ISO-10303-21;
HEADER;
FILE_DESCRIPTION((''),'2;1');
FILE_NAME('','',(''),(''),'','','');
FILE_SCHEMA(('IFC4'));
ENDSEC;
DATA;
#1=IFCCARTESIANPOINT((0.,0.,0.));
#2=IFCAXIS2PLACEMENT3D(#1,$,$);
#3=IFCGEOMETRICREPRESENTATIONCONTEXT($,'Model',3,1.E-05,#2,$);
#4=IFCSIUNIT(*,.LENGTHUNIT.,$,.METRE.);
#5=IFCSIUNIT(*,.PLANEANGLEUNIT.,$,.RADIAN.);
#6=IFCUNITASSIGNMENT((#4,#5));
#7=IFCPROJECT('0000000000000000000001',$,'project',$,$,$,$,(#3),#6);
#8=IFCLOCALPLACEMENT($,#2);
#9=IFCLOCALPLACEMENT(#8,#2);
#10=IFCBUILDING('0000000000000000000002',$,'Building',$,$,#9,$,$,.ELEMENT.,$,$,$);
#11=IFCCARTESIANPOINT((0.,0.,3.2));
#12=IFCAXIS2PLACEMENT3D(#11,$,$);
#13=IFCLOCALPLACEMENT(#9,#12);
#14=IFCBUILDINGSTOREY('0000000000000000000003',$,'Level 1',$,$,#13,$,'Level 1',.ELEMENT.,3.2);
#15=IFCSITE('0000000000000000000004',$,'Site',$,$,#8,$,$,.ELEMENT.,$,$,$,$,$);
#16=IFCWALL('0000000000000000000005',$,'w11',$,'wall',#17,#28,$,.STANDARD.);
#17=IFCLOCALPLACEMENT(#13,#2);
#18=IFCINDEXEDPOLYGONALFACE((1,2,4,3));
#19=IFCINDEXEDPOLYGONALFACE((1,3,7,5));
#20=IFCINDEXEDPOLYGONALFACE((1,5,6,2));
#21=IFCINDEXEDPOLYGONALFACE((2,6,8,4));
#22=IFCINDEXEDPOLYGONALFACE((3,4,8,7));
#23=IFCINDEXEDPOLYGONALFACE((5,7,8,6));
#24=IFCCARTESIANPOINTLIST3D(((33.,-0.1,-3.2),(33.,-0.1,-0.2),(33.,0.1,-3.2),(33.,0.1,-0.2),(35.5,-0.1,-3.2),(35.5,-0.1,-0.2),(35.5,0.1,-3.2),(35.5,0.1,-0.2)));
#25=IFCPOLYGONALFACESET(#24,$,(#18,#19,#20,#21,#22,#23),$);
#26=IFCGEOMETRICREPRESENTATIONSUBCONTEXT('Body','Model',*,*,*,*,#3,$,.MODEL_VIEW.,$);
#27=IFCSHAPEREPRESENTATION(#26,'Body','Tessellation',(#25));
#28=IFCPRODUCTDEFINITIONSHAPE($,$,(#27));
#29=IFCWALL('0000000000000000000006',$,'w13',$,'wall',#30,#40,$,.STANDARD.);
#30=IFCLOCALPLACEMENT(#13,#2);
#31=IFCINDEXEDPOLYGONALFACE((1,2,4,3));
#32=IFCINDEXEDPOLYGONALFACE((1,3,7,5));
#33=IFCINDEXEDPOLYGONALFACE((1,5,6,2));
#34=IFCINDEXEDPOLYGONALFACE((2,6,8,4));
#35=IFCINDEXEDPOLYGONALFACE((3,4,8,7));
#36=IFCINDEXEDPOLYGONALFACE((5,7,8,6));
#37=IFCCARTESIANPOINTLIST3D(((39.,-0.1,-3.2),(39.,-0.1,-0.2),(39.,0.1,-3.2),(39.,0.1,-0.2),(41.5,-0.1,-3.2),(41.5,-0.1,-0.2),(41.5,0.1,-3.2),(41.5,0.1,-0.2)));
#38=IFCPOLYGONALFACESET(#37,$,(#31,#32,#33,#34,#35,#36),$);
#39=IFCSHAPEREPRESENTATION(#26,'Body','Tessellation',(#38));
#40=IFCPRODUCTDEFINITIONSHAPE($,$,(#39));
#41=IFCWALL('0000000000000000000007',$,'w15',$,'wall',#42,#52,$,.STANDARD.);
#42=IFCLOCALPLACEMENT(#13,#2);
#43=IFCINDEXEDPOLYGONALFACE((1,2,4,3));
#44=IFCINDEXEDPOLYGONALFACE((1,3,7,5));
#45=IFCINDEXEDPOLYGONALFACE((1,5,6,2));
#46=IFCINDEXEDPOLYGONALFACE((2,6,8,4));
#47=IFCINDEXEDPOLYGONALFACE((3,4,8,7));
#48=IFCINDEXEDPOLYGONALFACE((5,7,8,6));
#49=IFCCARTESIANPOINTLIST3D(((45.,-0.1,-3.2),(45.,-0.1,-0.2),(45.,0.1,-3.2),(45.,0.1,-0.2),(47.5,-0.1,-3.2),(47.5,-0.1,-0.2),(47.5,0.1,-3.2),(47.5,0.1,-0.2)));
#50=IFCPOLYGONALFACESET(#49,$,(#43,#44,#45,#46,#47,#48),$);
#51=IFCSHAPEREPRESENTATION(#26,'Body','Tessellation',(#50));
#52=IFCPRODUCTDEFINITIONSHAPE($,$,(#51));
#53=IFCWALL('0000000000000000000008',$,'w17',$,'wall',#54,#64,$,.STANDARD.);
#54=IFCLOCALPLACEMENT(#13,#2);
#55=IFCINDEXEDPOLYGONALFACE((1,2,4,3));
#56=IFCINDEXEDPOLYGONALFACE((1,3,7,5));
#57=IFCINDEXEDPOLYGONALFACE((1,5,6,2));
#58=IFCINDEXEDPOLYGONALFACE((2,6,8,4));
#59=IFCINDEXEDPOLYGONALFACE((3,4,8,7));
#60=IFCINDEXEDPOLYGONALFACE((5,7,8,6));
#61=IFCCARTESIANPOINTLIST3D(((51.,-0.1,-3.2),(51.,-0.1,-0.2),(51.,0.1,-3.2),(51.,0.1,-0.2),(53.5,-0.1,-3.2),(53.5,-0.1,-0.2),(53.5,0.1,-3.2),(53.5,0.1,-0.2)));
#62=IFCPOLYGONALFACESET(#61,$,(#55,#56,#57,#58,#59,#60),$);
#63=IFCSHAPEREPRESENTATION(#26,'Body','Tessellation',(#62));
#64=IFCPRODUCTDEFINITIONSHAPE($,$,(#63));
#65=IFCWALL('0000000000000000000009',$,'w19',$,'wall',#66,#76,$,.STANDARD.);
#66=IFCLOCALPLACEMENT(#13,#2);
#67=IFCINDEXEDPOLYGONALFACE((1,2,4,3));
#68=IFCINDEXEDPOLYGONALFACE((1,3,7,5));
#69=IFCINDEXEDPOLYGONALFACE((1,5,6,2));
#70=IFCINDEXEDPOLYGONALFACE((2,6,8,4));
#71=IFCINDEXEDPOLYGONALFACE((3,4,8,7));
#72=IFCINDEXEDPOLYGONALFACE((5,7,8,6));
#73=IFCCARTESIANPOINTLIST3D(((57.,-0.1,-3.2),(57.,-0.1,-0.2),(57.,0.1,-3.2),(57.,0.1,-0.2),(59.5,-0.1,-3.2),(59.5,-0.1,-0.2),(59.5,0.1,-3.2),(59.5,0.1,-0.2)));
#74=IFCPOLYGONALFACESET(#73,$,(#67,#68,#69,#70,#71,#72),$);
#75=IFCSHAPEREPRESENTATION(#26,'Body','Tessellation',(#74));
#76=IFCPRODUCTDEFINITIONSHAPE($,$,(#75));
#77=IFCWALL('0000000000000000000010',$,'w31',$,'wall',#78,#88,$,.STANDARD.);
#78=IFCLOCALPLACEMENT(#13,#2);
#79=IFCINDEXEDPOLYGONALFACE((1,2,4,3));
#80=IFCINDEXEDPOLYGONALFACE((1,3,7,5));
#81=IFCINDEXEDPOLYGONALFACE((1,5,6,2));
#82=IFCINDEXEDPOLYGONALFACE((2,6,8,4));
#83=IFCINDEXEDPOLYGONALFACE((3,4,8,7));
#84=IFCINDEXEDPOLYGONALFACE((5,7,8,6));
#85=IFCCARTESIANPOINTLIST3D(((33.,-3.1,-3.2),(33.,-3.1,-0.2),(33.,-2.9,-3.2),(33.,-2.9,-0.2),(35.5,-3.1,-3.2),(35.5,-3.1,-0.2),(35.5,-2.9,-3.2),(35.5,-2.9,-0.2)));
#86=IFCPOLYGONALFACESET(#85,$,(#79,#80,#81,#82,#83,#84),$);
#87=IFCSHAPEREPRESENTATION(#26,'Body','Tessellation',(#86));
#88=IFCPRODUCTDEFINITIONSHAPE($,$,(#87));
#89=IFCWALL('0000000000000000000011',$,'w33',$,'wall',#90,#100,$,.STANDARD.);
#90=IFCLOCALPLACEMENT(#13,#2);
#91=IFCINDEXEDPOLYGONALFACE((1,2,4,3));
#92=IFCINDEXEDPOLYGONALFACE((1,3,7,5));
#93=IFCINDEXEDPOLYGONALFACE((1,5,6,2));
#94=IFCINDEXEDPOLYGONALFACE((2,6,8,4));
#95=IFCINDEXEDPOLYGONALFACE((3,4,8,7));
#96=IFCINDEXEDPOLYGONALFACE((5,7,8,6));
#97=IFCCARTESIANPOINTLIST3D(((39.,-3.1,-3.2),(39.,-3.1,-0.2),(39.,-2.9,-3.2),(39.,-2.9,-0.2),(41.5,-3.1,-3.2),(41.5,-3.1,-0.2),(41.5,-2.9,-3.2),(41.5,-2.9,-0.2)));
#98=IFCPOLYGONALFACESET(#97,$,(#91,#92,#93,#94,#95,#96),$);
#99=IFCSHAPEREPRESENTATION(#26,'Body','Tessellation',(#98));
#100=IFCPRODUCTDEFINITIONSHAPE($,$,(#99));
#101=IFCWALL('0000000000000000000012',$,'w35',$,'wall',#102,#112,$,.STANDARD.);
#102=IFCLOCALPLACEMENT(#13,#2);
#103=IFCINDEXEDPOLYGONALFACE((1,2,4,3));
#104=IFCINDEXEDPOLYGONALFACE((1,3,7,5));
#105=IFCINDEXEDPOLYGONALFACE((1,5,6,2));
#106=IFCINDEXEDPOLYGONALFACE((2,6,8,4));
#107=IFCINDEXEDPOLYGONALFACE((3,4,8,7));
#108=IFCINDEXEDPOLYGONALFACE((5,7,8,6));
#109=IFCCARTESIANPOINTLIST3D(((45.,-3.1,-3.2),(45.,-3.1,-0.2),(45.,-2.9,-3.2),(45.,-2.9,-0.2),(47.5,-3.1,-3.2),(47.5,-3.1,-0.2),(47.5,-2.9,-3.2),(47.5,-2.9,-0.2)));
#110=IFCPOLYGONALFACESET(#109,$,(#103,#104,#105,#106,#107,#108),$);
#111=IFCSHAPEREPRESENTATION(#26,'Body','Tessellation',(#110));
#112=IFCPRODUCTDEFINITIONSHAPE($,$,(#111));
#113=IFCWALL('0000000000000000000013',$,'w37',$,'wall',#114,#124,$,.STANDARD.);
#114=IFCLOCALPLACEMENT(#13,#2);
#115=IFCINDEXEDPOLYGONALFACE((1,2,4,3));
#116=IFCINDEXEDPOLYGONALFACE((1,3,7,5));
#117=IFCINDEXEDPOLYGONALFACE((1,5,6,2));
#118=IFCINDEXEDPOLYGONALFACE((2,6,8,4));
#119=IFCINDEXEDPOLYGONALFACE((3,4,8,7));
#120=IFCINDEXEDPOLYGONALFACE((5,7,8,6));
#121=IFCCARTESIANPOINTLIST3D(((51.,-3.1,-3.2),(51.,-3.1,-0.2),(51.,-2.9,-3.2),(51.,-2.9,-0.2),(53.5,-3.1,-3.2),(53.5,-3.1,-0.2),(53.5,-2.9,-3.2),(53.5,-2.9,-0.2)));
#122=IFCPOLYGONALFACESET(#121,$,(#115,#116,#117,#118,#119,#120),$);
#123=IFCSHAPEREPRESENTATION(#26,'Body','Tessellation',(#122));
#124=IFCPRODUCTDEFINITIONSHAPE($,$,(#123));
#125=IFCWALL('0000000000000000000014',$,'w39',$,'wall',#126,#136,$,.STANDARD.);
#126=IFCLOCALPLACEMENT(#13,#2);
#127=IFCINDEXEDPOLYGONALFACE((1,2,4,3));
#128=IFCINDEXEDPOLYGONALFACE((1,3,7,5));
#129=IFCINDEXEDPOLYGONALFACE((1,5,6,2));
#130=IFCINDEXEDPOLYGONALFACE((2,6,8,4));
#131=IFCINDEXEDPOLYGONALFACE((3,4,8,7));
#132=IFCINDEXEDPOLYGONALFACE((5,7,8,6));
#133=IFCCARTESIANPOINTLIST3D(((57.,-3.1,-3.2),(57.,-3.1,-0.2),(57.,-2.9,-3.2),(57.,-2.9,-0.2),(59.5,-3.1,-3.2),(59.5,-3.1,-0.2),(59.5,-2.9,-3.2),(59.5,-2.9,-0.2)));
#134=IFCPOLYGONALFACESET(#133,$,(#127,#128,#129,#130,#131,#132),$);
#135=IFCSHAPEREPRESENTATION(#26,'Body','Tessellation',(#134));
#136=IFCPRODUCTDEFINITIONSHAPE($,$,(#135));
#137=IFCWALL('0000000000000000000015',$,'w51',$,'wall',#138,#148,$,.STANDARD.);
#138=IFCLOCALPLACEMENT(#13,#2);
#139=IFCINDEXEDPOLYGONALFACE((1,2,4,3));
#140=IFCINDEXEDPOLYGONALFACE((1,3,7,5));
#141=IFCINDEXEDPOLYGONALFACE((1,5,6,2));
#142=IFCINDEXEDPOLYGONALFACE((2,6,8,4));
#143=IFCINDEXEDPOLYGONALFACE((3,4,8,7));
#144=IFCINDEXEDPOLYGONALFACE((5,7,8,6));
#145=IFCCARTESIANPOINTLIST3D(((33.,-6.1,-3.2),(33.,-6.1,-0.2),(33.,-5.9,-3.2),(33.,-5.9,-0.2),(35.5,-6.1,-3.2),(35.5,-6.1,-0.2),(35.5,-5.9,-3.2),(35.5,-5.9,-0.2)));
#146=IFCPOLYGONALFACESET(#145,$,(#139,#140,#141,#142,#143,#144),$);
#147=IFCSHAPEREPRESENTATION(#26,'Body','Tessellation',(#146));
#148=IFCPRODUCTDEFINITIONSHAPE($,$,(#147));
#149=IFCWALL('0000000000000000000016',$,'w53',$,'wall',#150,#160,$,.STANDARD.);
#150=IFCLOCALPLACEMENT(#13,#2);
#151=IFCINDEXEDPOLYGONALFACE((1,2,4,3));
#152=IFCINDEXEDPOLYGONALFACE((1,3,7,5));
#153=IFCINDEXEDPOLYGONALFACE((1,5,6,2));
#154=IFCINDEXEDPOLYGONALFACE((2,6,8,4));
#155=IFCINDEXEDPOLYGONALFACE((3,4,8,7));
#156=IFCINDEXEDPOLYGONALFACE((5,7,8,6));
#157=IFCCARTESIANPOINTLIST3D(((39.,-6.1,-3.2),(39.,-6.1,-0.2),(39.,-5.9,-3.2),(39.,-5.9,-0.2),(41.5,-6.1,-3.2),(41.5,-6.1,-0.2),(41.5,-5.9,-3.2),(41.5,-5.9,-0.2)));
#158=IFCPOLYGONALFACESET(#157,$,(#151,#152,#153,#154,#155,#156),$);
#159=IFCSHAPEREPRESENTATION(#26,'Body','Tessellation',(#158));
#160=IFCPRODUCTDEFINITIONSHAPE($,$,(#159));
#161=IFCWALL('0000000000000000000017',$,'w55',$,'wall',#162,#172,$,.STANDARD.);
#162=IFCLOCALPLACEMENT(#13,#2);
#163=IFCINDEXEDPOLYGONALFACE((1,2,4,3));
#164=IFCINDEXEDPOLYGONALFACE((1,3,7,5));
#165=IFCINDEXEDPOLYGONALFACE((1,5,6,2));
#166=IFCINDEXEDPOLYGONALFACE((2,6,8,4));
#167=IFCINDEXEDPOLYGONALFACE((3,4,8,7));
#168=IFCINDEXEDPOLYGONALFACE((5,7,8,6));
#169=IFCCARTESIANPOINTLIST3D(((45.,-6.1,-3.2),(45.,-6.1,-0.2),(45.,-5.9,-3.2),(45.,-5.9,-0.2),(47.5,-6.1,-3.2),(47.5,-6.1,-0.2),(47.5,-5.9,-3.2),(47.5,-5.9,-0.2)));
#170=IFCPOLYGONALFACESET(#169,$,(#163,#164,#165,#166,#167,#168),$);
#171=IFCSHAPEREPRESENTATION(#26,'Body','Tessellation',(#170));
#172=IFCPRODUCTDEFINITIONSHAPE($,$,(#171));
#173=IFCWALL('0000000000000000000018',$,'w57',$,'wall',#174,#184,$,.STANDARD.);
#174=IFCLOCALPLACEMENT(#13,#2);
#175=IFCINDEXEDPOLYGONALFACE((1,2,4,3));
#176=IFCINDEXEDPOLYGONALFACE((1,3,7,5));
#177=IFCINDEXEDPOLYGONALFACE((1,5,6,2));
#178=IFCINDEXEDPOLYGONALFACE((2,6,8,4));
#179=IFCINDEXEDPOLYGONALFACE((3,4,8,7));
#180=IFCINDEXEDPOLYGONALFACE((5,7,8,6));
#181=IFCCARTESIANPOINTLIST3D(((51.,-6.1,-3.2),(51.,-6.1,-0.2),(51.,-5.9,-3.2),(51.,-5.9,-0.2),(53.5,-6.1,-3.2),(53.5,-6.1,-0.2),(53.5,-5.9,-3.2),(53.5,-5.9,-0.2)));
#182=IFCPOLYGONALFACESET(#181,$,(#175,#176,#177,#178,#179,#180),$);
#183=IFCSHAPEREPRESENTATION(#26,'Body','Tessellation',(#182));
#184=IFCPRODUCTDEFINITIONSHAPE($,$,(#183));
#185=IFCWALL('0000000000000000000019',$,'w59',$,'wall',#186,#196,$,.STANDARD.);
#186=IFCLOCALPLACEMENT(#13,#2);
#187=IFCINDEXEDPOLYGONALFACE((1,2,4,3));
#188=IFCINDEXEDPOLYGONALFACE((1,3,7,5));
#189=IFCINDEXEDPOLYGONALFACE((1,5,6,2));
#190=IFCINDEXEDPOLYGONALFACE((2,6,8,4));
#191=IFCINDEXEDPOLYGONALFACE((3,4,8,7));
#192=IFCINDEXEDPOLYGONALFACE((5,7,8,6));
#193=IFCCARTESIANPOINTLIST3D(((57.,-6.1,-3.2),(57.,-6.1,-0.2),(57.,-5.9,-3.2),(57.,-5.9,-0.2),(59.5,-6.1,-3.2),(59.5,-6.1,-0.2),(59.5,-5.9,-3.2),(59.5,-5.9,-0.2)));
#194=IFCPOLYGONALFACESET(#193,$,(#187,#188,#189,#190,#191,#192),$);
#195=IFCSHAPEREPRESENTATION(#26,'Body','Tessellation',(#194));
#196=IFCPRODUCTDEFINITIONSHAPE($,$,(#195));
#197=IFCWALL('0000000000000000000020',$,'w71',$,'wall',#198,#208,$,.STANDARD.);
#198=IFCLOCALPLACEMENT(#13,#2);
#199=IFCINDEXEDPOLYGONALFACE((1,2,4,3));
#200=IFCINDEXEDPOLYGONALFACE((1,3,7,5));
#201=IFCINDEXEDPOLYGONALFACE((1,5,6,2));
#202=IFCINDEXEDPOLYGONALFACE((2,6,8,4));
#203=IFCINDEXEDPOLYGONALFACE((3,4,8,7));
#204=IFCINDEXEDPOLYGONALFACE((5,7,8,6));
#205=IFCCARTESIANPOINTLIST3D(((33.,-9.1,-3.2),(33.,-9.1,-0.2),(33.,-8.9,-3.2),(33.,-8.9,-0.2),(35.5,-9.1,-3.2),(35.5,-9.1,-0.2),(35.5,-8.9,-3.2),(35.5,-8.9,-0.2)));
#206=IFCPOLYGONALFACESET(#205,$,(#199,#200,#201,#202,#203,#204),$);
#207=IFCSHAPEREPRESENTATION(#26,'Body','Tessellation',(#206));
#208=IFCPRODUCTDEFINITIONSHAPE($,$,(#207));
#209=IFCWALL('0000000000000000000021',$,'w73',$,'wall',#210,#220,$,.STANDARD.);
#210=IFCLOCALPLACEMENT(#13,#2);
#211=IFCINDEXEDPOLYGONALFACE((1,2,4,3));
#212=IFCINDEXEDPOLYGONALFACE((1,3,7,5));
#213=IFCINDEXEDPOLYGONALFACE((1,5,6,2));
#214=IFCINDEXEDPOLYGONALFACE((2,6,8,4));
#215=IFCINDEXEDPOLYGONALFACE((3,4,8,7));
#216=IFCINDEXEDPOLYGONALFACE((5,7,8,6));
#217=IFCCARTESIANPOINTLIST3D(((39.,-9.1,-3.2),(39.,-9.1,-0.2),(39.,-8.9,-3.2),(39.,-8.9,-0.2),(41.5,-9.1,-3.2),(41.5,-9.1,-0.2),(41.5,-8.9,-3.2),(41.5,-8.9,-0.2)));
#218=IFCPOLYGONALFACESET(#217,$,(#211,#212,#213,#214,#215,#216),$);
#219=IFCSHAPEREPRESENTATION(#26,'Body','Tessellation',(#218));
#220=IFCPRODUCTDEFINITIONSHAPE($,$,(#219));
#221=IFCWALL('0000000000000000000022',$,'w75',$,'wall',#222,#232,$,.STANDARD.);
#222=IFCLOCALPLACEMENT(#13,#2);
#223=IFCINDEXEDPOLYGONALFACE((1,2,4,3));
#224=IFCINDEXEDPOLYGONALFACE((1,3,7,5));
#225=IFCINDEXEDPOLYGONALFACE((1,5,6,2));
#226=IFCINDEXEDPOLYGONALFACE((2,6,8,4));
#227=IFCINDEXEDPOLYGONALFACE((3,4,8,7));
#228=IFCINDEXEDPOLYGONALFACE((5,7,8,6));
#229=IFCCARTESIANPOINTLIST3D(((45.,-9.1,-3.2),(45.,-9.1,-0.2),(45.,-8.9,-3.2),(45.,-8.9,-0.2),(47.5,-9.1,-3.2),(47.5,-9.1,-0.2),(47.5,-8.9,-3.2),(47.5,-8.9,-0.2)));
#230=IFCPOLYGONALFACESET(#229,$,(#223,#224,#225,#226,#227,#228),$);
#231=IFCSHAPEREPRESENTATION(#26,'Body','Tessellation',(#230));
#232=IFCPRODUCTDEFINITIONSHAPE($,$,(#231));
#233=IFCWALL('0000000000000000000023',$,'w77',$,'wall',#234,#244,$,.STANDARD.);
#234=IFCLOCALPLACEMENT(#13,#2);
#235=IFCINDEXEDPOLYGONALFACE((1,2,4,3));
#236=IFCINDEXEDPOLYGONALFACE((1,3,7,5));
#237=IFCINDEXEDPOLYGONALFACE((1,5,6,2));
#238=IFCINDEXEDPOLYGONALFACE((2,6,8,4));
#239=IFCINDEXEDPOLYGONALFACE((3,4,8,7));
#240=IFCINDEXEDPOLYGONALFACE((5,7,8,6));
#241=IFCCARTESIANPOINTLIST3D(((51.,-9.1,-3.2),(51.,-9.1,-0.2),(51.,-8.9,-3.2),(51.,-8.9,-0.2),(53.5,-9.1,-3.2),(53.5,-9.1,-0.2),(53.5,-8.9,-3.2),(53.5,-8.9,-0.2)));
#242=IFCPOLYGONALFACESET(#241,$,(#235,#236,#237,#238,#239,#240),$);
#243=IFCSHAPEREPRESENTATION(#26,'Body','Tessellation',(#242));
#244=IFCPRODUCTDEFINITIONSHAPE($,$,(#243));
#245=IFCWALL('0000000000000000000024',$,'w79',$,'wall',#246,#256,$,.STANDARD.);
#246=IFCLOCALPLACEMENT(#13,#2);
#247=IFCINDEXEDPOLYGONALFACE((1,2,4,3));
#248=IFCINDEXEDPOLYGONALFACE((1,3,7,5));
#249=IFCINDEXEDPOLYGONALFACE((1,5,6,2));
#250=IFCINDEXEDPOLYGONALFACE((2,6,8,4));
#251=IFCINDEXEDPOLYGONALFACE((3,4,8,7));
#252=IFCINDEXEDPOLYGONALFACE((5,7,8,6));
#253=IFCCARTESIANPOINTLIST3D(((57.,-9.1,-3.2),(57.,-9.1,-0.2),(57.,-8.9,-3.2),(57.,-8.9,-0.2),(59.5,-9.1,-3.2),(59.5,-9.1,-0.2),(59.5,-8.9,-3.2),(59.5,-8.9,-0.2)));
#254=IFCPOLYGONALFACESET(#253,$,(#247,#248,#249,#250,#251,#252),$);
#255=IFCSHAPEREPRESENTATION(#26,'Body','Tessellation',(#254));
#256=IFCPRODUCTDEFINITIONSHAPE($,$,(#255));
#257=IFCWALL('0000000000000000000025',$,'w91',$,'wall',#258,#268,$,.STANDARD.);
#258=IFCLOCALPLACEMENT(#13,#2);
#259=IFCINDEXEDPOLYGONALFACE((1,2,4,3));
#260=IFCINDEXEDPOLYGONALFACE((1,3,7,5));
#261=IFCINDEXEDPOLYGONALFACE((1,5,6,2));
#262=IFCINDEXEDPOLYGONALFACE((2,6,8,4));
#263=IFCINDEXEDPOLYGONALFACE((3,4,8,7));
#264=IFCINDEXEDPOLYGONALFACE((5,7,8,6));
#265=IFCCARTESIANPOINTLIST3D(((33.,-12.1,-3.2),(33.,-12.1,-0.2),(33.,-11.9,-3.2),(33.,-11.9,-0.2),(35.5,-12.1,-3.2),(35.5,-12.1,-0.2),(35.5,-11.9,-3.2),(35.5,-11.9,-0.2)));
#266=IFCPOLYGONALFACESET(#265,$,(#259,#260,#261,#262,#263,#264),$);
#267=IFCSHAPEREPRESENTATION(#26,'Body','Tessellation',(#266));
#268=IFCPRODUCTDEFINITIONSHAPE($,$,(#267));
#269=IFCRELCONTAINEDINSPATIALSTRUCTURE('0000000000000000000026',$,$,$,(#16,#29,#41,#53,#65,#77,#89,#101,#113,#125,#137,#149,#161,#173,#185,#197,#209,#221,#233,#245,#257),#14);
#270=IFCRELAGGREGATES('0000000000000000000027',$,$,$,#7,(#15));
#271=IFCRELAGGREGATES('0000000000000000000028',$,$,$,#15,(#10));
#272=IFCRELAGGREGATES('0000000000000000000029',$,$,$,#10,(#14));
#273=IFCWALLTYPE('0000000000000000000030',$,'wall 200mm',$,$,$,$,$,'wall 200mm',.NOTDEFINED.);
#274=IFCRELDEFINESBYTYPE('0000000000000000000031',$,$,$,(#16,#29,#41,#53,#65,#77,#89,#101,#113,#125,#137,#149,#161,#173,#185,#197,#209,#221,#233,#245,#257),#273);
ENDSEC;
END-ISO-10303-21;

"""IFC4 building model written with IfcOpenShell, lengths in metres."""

from ifc_helpers import new_model, si_unit, frame, frame_2d, origin, place, context, subcontext, project, spatial, rectangle, extrude, type_object, element, save


model = new_model("IFC4")

# Units and contexts
model_context = context("Model", 3, precision=1e-05, world=origin())
body_context = subcontext(model_context, "Body", "Model", "MODEL_VIEW")
ifc_project = project(units=[si_unit("LENGTHUNIT", "METRE"), si_unit("PLANEANGLEUNIT", "RADIAN")], contexts=[model_context])

# Site, building, storey
site_placement = place(None, origin())
site = spatial("IfcSite", under=ifc_project, at=site_placement, Name="Site", CompositionType="ELEMENT")
building_placement = place(site_placement, origin())
building = spatial("IfcBuilding", under=site, at=building_placement, Name="Building", CompositionType="ELEMENT")
storey_placement = place(building_placement, frame((0.0, 0.0, 3.2)))
storey = spatial("IfcBuildingStorey", under=building, at=storey_placement, Name="Level 1", LongName="Level 1", CompositionType="ELEMENT", Elevation=3.2)

# Walls
wall_type = type_object("IfcWallType", Name="wall 200mm", ElementType="wall 200mm", PredefinedType="NOTDEFINED")
for number, where, z_axis, x_axis, name in (
    (1, (33.0, 0.0, -3.2), (0.0, 0.0, 1.0), (1.0, 0.0, 0.0), "w11"),
    (2, (39.0, 0.0, -3.2), (0.0, 0.0, 1.0), (1.0, 0.0, 0.0), "w13"),
    (3, (45.0, 0.0, -3.2), (0.0, 0.0, 1.0), (1.0, 0.0, 0.0), "w15"),
    (4, (51.0, 0.0, -3.2), (0.0, 0.0, 1.0), (1.0, 0.0, 0.0), "w17"),
    (5, (57.0, 0.0, -3.2), (0.0, 0.0, 1.0), (1.0, 0.0, 0.0), "w19"),
    (6, (33.0, -3.0, -3.2), (0.0, 0.0, 1.0), (1.0, 0.0, 0.0), "w31"),
    (7, (39.0, -3.0, -3.2), (0.0, 0.0, 1.0), (1.0, 0.0, 0.0), "w33"),
    (8, (45.0, -3.0, -3.2), (0.0, 0.0, 1.0), (1.0, 0.0, 0.0), "w35"),
    (9, (51.0, -3.0, -3.2), (0.0, 0.0, 1.0), (1.0, 0.0, 0.0), "w37"),
    (10, (57.0, -3.0, -3.2), (0.0, 0.0, 1.0), (1.0, 0.0, 0.0), "w39"),
    (11, (33.0, -6.0, -3.2), (0.0, 0.0, 1.0), (1.0, 0.0, 0.0), "w51"),
    (12, (39.0, -6.0, -3.2), (0.0, 0.0, 1.0), (1.0, 0.0, 0.0), "w53"),
    (13, (45.0, -6.0, -3.2), (0.0, 0.0, 1.0), (1.0, 0.0, 0.0), "w55"),
    (14, (51.0, -6.0, -3.2), (0.0, 0.0, 1.0), (1.0, 0.0, 0.0), "w57"),
    (15, (57.0, -6.0, -3.2), (0.0, 0.0, 1.0), (1.0, 0.0, 0.0), "w59"),
    (16, (33.0, -9.0, -3.2), (0.0, 0.0, 1.0), (1.0, 0.0, 0.0), "w71"),
    (17, (39.0, -9.0, -3.2), (0.0, 0.0, 1.0), (1.0, 0.0, 0.0), "w73"),
    (18, (45.0, -9.0, -3.2), (0.0, 0.0, 1.0), (1.0, 0.0, 0.0), "w75"),
    (19, (51.0, -9.0, -3.2), (0.0, 0.0, 1.0), (1.0, 0.0, 0.0), "w77"),
    (20, (57.0, -9.0, -3.2), (0.0, 0.0, 1.0), (1.0, 0.0, 0.0), "w79"),
    (21, (33.0, -12.0, -3.2), (0.0, 0.0, 1.0), (1.0, 0.0, 0.0), "w91"),
):
    element("IfcWall", number, at=place(storey_placement, frame(where, z_axis=z_axis, x_axis=x_axis)), inside=storey, type_object=wall_type, Name=name, ObjectType="wall", PredefinedType="STANDARD", context=body_context, shape_type="SweptSolid", body=[
        extrude(rectangle(XDim=2.5, YDim=0.2, at=frame_2d((1.25, 0.0))), origin(), (0.0, 0.0, 1.0), 3.0),
    ])

save(model, "model.ifc")
